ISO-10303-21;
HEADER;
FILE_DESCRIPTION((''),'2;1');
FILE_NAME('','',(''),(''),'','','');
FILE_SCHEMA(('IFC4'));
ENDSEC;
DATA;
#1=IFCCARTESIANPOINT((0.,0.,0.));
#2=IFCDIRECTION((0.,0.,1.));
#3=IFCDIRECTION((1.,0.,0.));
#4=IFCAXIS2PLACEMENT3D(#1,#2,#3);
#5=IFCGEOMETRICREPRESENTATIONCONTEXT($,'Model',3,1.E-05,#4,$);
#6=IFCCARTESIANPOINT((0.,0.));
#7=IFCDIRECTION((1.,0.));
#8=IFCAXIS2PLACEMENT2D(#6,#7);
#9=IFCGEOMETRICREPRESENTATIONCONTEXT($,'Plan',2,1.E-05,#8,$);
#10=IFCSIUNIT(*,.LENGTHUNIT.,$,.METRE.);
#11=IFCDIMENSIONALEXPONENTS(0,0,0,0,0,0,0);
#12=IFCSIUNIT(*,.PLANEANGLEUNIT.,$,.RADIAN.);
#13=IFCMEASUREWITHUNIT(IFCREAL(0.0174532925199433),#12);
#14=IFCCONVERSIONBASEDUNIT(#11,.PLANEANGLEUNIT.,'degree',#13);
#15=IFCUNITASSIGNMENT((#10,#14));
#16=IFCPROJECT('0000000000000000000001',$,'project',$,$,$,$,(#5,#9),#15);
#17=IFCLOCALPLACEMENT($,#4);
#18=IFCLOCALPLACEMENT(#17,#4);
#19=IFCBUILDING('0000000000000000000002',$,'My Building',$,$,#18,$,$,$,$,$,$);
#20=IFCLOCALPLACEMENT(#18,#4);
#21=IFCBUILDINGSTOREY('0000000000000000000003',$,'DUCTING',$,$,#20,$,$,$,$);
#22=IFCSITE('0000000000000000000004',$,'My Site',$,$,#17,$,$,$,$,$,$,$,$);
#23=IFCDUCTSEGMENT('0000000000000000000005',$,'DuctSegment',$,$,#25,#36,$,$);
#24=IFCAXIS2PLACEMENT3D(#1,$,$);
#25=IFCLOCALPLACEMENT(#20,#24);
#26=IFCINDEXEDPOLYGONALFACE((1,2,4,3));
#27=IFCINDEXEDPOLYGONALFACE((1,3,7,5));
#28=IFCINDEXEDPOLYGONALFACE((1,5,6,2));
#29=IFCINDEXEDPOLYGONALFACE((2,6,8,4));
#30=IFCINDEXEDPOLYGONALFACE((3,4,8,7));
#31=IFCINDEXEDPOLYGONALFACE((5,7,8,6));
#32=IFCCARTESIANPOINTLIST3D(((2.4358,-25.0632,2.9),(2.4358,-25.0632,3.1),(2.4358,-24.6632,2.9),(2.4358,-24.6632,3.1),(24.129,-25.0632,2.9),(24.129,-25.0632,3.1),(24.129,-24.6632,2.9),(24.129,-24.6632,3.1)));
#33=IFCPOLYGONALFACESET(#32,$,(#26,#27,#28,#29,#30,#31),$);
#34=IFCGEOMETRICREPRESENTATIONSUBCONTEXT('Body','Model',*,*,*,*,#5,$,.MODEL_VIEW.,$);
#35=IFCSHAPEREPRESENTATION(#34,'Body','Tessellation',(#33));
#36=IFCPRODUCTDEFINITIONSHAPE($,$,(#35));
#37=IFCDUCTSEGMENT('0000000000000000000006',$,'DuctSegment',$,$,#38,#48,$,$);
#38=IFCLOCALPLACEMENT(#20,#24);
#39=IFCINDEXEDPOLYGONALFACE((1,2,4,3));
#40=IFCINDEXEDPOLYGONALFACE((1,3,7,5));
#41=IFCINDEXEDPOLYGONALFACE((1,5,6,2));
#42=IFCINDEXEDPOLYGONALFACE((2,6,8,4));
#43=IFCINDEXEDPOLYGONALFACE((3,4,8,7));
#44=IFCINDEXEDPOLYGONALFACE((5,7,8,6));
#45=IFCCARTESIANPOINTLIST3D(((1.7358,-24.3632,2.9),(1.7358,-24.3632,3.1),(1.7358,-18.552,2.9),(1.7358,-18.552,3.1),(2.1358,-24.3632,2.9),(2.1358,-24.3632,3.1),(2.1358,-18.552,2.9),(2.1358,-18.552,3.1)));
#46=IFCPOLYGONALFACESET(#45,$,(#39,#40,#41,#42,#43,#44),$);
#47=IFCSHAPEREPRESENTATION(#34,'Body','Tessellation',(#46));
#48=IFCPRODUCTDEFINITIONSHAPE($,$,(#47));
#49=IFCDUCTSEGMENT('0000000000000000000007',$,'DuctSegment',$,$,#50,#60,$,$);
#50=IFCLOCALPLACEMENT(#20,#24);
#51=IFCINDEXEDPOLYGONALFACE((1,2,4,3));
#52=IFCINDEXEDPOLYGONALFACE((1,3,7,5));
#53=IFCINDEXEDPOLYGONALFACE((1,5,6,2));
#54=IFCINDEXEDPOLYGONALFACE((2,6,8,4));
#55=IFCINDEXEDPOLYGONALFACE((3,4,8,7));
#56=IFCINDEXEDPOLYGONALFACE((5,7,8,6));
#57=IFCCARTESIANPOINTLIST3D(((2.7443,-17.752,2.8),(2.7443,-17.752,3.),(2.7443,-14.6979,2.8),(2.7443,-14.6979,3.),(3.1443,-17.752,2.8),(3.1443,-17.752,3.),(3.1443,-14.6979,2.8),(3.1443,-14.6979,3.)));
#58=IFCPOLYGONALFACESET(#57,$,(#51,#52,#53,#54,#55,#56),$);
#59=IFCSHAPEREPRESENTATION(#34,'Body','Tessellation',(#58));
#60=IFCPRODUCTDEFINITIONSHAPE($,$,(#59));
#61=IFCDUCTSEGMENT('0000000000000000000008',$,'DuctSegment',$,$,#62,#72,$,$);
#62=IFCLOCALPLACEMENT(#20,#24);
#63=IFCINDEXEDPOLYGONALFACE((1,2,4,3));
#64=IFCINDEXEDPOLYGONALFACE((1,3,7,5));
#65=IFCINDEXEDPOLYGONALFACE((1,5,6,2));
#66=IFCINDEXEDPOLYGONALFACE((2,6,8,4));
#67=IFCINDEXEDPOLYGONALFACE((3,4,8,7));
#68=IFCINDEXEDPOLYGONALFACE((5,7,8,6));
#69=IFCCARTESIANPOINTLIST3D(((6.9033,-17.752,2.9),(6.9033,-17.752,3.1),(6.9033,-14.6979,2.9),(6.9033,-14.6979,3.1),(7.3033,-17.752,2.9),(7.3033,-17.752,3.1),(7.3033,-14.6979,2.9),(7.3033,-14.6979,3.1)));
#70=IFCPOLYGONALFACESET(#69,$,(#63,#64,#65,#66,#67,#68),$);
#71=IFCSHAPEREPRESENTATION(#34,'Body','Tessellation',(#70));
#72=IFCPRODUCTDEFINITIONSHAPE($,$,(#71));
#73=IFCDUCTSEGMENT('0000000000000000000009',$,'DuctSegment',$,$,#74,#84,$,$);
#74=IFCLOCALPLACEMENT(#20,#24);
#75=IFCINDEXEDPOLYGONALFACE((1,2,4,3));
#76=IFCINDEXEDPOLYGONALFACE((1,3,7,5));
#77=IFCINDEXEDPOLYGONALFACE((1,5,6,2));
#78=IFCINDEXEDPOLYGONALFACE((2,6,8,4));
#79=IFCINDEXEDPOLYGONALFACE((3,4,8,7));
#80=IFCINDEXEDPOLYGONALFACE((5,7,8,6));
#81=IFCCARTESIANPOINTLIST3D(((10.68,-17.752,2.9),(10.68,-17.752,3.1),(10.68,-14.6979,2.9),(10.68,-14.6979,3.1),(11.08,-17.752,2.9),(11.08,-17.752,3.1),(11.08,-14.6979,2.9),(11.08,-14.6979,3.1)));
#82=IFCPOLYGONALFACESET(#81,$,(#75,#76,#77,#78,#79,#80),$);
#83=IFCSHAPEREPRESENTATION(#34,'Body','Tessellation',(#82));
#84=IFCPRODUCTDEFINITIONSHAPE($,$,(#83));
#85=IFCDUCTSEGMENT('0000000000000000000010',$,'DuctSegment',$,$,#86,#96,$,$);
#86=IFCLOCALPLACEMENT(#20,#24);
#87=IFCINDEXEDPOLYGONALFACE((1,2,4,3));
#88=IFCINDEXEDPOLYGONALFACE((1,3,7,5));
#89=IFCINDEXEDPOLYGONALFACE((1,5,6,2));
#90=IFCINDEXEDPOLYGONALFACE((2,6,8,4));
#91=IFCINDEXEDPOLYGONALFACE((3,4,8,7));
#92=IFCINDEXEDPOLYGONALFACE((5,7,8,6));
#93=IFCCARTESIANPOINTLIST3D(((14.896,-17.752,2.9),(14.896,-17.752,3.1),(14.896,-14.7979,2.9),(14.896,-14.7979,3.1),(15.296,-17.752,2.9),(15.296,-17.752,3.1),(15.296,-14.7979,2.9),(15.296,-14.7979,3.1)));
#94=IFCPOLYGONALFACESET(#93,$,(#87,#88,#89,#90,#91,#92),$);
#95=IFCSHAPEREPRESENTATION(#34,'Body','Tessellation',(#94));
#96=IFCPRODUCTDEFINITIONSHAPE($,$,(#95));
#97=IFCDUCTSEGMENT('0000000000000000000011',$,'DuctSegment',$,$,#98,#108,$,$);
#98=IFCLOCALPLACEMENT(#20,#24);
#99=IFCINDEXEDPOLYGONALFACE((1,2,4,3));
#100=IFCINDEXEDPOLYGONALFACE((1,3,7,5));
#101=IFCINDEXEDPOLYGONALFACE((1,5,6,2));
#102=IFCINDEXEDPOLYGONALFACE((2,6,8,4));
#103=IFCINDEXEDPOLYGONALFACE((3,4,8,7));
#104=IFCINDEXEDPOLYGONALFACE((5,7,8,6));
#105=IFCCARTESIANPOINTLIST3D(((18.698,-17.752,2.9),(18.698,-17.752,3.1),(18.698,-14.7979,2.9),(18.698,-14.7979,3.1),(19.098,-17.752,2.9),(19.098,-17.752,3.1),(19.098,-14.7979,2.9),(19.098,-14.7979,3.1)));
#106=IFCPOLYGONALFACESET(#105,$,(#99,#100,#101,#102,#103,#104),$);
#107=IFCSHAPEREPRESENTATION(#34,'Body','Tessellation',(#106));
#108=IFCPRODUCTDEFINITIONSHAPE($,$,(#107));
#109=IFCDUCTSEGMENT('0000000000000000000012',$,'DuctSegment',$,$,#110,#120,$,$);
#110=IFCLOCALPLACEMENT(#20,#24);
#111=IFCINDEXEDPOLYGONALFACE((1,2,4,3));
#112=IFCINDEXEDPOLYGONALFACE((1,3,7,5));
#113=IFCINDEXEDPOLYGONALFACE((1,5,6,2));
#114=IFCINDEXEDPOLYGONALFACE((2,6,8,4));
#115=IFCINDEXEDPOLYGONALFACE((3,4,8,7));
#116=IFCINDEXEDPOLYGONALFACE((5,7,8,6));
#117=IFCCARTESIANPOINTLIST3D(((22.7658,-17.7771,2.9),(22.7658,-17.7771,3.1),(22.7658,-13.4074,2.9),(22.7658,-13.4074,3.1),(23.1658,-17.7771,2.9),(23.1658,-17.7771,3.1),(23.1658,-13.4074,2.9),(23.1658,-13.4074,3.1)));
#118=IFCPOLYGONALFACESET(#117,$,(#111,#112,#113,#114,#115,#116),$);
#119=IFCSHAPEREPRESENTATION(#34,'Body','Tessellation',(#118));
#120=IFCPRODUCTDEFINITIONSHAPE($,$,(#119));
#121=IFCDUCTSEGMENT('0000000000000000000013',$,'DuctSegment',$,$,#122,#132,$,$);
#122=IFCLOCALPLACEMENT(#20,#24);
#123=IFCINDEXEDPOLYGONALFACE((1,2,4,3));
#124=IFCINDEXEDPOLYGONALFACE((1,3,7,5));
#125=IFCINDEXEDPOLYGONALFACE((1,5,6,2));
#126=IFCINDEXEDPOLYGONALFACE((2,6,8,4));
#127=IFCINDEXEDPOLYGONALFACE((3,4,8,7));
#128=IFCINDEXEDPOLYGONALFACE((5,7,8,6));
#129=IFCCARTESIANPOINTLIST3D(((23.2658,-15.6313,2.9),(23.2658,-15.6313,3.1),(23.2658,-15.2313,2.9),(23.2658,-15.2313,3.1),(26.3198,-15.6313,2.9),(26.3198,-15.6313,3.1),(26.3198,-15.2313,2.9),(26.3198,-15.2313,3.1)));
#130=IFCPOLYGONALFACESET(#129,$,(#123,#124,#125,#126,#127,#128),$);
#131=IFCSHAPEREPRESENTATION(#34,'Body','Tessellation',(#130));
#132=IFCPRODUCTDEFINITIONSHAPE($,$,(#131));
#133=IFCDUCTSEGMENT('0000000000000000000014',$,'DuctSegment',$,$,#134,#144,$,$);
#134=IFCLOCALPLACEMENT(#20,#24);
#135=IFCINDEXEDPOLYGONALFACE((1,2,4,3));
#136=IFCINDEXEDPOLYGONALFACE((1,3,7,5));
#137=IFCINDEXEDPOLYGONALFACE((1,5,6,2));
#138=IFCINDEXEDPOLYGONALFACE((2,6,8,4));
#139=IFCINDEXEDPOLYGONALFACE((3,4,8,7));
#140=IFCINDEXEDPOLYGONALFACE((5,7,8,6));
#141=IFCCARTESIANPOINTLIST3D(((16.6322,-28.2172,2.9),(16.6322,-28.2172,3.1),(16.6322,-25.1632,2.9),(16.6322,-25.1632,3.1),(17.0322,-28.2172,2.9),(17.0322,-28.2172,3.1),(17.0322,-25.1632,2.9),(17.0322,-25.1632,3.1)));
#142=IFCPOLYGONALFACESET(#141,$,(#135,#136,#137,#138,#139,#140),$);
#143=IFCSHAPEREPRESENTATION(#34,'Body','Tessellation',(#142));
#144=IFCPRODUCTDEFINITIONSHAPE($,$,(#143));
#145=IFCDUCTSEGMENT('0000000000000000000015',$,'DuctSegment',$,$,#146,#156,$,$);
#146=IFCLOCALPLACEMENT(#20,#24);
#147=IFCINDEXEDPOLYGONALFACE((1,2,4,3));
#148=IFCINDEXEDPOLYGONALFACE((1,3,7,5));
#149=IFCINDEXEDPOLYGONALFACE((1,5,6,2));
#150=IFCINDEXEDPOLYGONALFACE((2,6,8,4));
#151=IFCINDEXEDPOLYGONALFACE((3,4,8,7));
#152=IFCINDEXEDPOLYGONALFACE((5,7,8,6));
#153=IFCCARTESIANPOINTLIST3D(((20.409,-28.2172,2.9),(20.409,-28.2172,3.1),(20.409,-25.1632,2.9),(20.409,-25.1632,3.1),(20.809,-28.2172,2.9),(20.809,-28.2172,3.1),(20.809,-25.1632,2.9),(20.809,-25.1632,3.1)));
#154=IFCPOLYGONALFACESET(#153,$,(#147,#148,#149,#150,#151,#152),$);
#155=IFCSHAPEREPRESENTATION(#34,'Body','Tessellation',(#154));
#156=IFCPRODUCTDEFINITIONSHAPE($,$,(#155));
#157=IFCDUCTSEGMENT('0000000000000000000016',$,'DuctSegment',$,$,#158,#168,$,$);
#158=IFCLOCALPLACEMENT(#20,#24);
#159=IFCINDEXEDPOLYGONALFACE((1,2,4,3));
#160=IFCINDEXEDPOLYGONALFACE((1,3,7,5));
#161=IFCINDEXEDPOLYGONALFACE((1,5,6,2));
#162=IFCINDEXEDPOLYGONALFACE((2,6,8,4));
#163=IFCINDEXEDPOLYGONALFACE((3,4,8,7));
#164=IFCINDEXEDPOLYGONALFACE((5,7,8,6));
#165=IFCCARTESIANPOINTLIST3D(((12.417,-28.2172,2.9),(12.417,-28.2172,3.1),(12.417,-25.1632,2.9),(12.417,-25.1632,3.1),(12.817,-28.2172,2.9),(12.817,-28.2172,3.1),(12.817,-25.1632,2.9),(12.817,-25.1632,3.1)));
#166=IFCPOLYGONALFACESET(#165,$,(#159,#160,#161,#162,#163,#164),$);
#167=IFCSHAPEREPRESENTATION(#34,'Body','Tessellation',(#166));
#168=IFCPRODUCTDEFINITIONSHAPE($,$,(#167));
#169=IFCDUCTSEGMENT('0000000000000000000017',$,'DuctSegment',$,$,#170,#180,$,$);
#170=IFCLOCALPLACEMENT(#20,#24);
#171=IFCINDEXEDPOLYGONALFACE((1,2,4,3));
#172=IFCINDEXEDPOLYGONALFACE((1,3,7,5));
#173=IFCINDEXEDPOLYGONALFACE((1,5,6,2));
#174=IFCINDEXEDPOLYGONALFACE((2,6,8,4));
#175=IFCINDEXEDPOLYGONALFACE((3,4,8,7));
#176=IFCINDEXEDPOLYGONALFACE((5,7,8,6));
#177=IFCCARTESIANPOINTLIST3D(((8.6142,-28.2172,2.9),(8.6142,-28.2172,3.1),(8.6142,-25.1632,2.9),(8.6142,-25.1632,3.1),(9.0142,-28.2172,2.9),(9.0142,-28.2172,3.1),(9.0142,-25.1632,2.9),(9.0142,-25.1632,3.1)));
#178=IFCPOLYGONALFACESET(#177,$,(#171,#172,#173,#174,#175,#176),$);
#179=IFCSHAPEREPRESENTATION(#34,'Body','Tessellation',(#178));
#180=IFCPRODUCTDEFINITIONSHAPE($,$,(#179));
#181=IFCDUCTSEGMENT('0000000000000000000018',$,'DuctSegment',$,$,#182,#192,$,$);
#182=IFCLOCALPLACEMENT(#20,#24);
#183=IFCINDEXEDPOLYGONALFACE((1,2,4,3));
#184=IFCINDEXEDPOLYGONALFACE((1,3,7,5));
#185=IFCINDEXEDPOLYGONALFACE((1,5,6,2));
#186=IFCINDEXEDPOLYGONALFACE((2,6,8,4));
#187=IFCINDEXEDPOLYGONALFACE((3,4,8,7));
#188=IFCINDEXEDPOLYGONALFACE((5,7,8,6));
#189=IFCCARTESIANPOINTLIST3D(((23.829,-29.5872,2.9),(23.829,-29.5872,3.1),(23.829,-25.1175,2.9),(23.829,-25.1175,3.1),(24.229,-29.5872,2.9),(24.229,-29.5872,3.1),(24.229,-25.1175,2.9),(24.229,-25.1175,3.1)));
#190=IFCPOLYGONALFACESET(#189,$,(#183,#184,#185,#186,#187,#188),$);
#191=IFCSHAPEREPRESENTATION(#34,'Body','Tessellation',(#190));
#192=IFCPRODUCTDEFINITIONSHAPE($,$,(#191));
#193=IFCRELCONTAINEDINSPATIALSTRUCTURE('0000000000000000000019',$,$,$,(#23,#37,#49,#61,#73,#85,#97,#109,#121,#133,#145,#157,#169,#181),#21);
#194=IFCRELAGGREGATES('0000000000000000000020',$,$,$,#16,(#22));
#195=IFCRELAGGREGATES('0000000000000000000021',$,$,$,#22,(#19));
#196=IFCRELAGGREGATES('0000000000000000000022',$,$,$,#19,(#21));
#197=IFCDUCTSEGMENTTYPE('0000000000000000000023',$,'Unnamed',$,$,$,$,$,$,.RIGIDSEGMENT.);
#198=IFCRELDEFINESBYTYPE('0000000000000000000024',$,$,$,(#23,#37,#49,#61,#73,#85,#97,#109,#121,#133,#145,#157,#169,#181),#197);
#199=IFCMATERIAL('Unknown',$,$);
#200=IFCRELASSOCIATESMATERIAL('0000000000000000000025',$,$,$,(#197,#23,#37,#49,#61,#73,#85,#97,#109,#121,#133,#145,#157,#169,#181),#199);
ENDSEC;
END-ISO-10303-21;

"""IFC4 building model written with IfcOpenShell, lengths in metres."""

from ifc_helpers import new_model, entity, si_unit, converted_unit, frame, origin_with_axes, origin_2d_with_axis, place, context, subcontext, project, spatial, rectangle, extrude, material, material_profile, profile_set, profile_usage, type_object, element, save


model = new_model("IFC4")

# Units and contexts
model_context = context("Model", 3, precision=1e-05, world=origin_with_axes())
plan_context = context("Plan", 2, precision=1e-05, world=origin_2d_with_axis())
body_context = subcontext(model_context, "Body", "Model", "MODEL_VIEW")
ifc_project = project(units=[si_unit("LENGTHUNIT", "METRE"), converted_unit("PLANEANGLEUNIT", "degree", entity("IfcReal", 0.0174532925199433), si_unit("PLANEANGLEUNIT", "RADIAN"), dimensions=[0, 0, 0, 0, 0, 0, 0])], contexts=[model_context, plan_context])

# Site, building, storey
site_placement = place(None, origin_with_axes())
site = spatial("IfcSite", under=ifc_project, at=site_placement, Name="My Site")
building_placement = place(site_placement, origin_with_axes())
building = spatial("IfcBuilding", under=site, at=building_placement, Name="My Building")
storey_placement = place(building_placement, origin_with_axes())
storey = spatial("IfcBuildingStorey", under=building, at=storey_placement, Name="DUCTING")

# Duct segments
ifc_material = material(Name="Unknown")
ifc_material_profile = material_profile(ifc_material, rectangle(XDim=0.4, YDim=0.2))
ifc_profile_set = profile_set([ifc_material_profile])
ifc_profile_usage_1 = profile_usage(ifc_profile_set, cardinal=5)
duct_segment_type = type_object("IfcDuctSegmentType", Name="Unnamed", PredefinedType="RIGIDSEGMENT", material=ifc_profile_set)
duct_segment_1_placement = place(storey_placement, frame((24.129, -24.8632, 3.0), z_axis=(-1.0, 0.0, 0.0), x_axis=(0.0, -1.0, 0.0)))
element("IfcDuctSegment", 1, at=duct_segment_1_placement, inside=storey, type_object=duct_segment_type, material=ifc_profile_usage_1, Name="DuctSegment", context=body_context, shape_type="SweptSolid", body=[
    extrude(rectangle(XDim=0.4, YDim=0.2), origin_with_axes(), (0.0, 0.0, 1.0), 21.6932),
])
ifc_profile_usage_2 = profile_usage(ifc_profile_set, cardinal=5)
duct_segment_2_placement = place(storey_placement, frame((1.9358, -18.552, 3.0), z_axis=(0.0, -1.0, 0.0), x_axis=(1.0, 0.0, 0.0)))
element("IfcDuctSegment", 2, at=duct_segment_2_placement, inside=storey, type_object=duct_segment_type, material=ifc_profile_usage_2, Name="DuctSegment", context=body_context, shape_type="SweptSolid", body=[
    extrude(rectangle(XDim=0.4, YDim=0.2), origin_with_axes(), (0.0, 0.0, 1.0), 5.8113),
])
ifc_profile_usage_3 = profile_usage(ifc_profile_set, cardinal=5)
duct_segment_3_placement = place(storey_placement, frame((2.9443, -17.752, 2.9), z_axis=(0.0, 1.0, 0.0), x_axis=(-1.0, 0.0, 0.0)))
element("IfcDuctSegment", 3, at=duct_segment_3_placement, inside=storey, type_object=duct_segment_type, material=ifc_profile_usage_3, Name="DuctSegment", context=body_context, shape_type="SweptSolid", body=[
    extrude(rectangle(XDim=0.4, YDim=0.2), origin_with_axes(), (0.0, 0.0, 1.0), 3.054),
])
ifc_profile_usage_4 = profile_usage(ifc_profile_set, cardinal=5)
duct_segment_4_placement = place(storey_placement, frame((7.1033, -17.752, 3.0), z_axis=(0.0, 1.0, 0.0), x_axis=(-1.0, 0.0, 0.0)))
element("IfcDuctSegment", 4, at=duct_segment_4_placement, inside=storey, type_object=duct_segment_type, material=ifc_profile_usage_4, Name="DuctSegment", context=body_context, shape_type="SweptSolid", body=[
    extrude(rectangle(XDim=0.4, YDim=0.2), origin_with_axes(), (0.0, 0.0, 1.0), 3.054),
])
ifc_profile_usage_5 = profile_usage(ifc_profile_set, cardinal=5)
duct_segment_5_placement = place(storey_placement, frame((10.88, -17.752, 3.0), z_axis=(0.0, 1.0, 0.0), x_axis=(-1.0, 0.0, 0.0)))
element("IfcDuctSegment", 5, at=duct_segment_5_placement, inside=storey, type_object=duct_segment_type, material=ifc_profile_usage_5, Name="DuctSegment", context=body_context, shape_type="SweptSolid", body=[
    extrude(rectangle(XDim=0.4, YDim=0.2), origin_with_axes(), (0.0, 0.0, 1.0), 3.054),
])
ifc_profile_usage_6 = profile_usage(ifc_profile_set, cardinal=5)
duct_segment_6_placement = place(storey_placement, frame((15.096, -17.752, 3.0), z_axis=(0.0, 1.0, 0.0), x_axis=(-1.0, 0.0, 0.0)))
element("IfcDuctSegment", 6, at=duct_segment_6_placement, inside=storey, type_object=duct_segment_type, material=ifc_profile_usage_6, Name="DuctSegment", context=body_context, shape_type="SweptSolid", body=[
    extrude(rectangle(XDim=0.4, YDim=0.2), origin_with_axes(), (0.0, 0.0, 1.0), 2.954),
])
ifc_profile_usage_7 = profile_usage(ifc_profile_set, cardinal=5)
duct_segment_7_placement = place(storey_placement, frame((18.898, -17.752, 3.0), z_axis=(0.0, 1.0, 0.0), x_axis=(-1.0, 0.0, 0.0)))
element("IfcDuctSegment", 7, at=duct_segment_7_placement, inside=storey, type_object=duct_segment_type, material=ifc_profile_usage_7, Name="DuctSegment", context=body_context, shape_type="SweptSolid", body=[
    extrude(rectangle(XDim=0.4, YDim=0.2), origin_with_axes(), (0.0, 0.0, 1.0), 2.954),
])
ifc_profile_usage_8 = profile_usage(ifc_profile_set, cardinal=5)
duct_segment_8_placement = place(storey_placement, frame((22.9658, -17.7771, 3.0), z_axis=(0.0, 1.0, 0.0), x_axis=(-1.0, 0.0, 0.0)))
element("IfcDuctSegment", 8, at=duct_segment_8_placement, inside=storey, type_object=duct_segment_type, material=ifc_profile_usage_8, Name="DuctSegment", context=body_context, shape_type="SweptSolid", body=[
    extrude(rectangle(XDim=0.4, YDim=0.2), origin_with_axes(), (0.0, 0.0, 1.0), 4.3697),
])
ifc_profile_usage_9 = profile_usage(ifc_profile_set, cardinal=5)
duct_segment_9_placement = place(storey_placement, frame((23.2658, -15.4313, 3.0), z_axis=(1.0, 0.0, 0.0), x_axis=(0.0, 1.0, 0.0)))
element("IfcDuctSegment", 9, at=duct_segment_9_placement, inside=storey, type_object=duct_segment_type, material=ifc_profile_usage_9, Name="DuctSegment", context=body_context, shape_type="SweptSolid", body=[
    extrude(rectangle(XDim=0.4, YDim=0.2), origin_with_axes(), (0.0, 0.0, 1.0), 3.054),
])
ifc_profile_usage_10 = profile_usage(ifc_profile_set, cardinal=5)
duct_segment_10_placement = place(storey_placement, frame((16.8322, -25.1632, 3.0), z_axis=(0.0, -1.0, 0.0), x_axis=(1.0, 0.0, 0.0)))
element("IfcDuctSegment", 10, at=duct_segment_10_placement, inside=storey, type_object=duct_segment_type, material=ifc_profile_usage_10, Name="DuctSegment", context=body_context, shape_type="SweptSolid", body=[
    extrude(rectangle(XDim=0.4, YDim=0.2), origin_with_axes(), (0.0, 0.0, 1.0), 3.054),
])
ifc_profile_usage_11 = profile_usage(ifc_profile_set, cardinal=5)
duct_segment_11_placement = place(storey_placement, frame((20.609, -25.1632, 3.0), z_axis=(0.0, -1.0, 0.0), x_axis=(1.0, 0.0, 0.0)))
element("IfcDuctSegment", 11, at=duct_segment_11_placement, inside=storey, type_object=duct_segment_type, material=ifc_profile_usage_11, Name="DuctSegment", context=body_context, shape_type="SweptSolid", body=[
    extrude(rectangle(XDim=0.4, YDim=0.2), origin_with_axes(), (0.0, 0.0, 1.0), 3.054),
])
ifc_profile_usage_12 = profile_usage(ifc_profile_set, cardinal=5)
duct_segment_12_placement = place(storey_placement, frame((12.617, -25.1632, 3.0), z_axis=(0.0, -1.0, 0.0), x_axis=(1.0, 0.0, 0.0)))
element("IfcDuctSegment", 12, at=duct_segment_12_placement, inside=storey, type_object=duct_segment_type, material=ifc_profile_usage_12, Name="DuctSegment", context=body_context, shape_type="SweptSolid", body=[
    extrude(rectangle(XDim=0.4, YDim=0.2), origin_with_axes(), (0.0, 0.0, 1.0), 3.054),
])
ifc_profile_usage_13 = profile_usage(ifc_profile_set, cardinal=5)
duct_segment_13_placement = place(storey_placement, frame((8.8142, -25.1632, 3.0), z_axis=(0.0, -1.0, 0.0), x_axis=(1.0, 0.0, 0.0)))
element("IfcDuctSegment", 13, at=duct_segment_13_placement, inside=storey, type_object=duct_segment_type, material=ifc_profile_usage_13, Name="DuctSegment", context=body_context, shape_type="SweptSolid", body=[
    extrude(rectangle(XDim=0.4, YDim=0.2), origin_with_axes(), (0.0, 0.0, 1.0), 3.054),
])
ifc_profile_usage_14 = profile_usage(ifc_profile_set, cardinal=5)
duct_segment_14_placement = place(storey_placement, frame((24.029, -25.1175, 3.0), z_axis=(0.0, -1.0, 0.0), x_axis=(1.0, 0.0, 0.0)))
element("IfcDuctSegment", 14, at=duct_segment_14_placement, inside=storey, type_object=duct_segment_type, material=ifc_profile_usage_14, Name="DuctSegment", context=body_context, shape_type="SweptSolid", body=[
    extrude(rectangle(XDim=0.4, YDim=0.2), origin_with_axes(), (0.0, 0.0, 1.0), 4.4697),
])

save(model, "model.ifc")
